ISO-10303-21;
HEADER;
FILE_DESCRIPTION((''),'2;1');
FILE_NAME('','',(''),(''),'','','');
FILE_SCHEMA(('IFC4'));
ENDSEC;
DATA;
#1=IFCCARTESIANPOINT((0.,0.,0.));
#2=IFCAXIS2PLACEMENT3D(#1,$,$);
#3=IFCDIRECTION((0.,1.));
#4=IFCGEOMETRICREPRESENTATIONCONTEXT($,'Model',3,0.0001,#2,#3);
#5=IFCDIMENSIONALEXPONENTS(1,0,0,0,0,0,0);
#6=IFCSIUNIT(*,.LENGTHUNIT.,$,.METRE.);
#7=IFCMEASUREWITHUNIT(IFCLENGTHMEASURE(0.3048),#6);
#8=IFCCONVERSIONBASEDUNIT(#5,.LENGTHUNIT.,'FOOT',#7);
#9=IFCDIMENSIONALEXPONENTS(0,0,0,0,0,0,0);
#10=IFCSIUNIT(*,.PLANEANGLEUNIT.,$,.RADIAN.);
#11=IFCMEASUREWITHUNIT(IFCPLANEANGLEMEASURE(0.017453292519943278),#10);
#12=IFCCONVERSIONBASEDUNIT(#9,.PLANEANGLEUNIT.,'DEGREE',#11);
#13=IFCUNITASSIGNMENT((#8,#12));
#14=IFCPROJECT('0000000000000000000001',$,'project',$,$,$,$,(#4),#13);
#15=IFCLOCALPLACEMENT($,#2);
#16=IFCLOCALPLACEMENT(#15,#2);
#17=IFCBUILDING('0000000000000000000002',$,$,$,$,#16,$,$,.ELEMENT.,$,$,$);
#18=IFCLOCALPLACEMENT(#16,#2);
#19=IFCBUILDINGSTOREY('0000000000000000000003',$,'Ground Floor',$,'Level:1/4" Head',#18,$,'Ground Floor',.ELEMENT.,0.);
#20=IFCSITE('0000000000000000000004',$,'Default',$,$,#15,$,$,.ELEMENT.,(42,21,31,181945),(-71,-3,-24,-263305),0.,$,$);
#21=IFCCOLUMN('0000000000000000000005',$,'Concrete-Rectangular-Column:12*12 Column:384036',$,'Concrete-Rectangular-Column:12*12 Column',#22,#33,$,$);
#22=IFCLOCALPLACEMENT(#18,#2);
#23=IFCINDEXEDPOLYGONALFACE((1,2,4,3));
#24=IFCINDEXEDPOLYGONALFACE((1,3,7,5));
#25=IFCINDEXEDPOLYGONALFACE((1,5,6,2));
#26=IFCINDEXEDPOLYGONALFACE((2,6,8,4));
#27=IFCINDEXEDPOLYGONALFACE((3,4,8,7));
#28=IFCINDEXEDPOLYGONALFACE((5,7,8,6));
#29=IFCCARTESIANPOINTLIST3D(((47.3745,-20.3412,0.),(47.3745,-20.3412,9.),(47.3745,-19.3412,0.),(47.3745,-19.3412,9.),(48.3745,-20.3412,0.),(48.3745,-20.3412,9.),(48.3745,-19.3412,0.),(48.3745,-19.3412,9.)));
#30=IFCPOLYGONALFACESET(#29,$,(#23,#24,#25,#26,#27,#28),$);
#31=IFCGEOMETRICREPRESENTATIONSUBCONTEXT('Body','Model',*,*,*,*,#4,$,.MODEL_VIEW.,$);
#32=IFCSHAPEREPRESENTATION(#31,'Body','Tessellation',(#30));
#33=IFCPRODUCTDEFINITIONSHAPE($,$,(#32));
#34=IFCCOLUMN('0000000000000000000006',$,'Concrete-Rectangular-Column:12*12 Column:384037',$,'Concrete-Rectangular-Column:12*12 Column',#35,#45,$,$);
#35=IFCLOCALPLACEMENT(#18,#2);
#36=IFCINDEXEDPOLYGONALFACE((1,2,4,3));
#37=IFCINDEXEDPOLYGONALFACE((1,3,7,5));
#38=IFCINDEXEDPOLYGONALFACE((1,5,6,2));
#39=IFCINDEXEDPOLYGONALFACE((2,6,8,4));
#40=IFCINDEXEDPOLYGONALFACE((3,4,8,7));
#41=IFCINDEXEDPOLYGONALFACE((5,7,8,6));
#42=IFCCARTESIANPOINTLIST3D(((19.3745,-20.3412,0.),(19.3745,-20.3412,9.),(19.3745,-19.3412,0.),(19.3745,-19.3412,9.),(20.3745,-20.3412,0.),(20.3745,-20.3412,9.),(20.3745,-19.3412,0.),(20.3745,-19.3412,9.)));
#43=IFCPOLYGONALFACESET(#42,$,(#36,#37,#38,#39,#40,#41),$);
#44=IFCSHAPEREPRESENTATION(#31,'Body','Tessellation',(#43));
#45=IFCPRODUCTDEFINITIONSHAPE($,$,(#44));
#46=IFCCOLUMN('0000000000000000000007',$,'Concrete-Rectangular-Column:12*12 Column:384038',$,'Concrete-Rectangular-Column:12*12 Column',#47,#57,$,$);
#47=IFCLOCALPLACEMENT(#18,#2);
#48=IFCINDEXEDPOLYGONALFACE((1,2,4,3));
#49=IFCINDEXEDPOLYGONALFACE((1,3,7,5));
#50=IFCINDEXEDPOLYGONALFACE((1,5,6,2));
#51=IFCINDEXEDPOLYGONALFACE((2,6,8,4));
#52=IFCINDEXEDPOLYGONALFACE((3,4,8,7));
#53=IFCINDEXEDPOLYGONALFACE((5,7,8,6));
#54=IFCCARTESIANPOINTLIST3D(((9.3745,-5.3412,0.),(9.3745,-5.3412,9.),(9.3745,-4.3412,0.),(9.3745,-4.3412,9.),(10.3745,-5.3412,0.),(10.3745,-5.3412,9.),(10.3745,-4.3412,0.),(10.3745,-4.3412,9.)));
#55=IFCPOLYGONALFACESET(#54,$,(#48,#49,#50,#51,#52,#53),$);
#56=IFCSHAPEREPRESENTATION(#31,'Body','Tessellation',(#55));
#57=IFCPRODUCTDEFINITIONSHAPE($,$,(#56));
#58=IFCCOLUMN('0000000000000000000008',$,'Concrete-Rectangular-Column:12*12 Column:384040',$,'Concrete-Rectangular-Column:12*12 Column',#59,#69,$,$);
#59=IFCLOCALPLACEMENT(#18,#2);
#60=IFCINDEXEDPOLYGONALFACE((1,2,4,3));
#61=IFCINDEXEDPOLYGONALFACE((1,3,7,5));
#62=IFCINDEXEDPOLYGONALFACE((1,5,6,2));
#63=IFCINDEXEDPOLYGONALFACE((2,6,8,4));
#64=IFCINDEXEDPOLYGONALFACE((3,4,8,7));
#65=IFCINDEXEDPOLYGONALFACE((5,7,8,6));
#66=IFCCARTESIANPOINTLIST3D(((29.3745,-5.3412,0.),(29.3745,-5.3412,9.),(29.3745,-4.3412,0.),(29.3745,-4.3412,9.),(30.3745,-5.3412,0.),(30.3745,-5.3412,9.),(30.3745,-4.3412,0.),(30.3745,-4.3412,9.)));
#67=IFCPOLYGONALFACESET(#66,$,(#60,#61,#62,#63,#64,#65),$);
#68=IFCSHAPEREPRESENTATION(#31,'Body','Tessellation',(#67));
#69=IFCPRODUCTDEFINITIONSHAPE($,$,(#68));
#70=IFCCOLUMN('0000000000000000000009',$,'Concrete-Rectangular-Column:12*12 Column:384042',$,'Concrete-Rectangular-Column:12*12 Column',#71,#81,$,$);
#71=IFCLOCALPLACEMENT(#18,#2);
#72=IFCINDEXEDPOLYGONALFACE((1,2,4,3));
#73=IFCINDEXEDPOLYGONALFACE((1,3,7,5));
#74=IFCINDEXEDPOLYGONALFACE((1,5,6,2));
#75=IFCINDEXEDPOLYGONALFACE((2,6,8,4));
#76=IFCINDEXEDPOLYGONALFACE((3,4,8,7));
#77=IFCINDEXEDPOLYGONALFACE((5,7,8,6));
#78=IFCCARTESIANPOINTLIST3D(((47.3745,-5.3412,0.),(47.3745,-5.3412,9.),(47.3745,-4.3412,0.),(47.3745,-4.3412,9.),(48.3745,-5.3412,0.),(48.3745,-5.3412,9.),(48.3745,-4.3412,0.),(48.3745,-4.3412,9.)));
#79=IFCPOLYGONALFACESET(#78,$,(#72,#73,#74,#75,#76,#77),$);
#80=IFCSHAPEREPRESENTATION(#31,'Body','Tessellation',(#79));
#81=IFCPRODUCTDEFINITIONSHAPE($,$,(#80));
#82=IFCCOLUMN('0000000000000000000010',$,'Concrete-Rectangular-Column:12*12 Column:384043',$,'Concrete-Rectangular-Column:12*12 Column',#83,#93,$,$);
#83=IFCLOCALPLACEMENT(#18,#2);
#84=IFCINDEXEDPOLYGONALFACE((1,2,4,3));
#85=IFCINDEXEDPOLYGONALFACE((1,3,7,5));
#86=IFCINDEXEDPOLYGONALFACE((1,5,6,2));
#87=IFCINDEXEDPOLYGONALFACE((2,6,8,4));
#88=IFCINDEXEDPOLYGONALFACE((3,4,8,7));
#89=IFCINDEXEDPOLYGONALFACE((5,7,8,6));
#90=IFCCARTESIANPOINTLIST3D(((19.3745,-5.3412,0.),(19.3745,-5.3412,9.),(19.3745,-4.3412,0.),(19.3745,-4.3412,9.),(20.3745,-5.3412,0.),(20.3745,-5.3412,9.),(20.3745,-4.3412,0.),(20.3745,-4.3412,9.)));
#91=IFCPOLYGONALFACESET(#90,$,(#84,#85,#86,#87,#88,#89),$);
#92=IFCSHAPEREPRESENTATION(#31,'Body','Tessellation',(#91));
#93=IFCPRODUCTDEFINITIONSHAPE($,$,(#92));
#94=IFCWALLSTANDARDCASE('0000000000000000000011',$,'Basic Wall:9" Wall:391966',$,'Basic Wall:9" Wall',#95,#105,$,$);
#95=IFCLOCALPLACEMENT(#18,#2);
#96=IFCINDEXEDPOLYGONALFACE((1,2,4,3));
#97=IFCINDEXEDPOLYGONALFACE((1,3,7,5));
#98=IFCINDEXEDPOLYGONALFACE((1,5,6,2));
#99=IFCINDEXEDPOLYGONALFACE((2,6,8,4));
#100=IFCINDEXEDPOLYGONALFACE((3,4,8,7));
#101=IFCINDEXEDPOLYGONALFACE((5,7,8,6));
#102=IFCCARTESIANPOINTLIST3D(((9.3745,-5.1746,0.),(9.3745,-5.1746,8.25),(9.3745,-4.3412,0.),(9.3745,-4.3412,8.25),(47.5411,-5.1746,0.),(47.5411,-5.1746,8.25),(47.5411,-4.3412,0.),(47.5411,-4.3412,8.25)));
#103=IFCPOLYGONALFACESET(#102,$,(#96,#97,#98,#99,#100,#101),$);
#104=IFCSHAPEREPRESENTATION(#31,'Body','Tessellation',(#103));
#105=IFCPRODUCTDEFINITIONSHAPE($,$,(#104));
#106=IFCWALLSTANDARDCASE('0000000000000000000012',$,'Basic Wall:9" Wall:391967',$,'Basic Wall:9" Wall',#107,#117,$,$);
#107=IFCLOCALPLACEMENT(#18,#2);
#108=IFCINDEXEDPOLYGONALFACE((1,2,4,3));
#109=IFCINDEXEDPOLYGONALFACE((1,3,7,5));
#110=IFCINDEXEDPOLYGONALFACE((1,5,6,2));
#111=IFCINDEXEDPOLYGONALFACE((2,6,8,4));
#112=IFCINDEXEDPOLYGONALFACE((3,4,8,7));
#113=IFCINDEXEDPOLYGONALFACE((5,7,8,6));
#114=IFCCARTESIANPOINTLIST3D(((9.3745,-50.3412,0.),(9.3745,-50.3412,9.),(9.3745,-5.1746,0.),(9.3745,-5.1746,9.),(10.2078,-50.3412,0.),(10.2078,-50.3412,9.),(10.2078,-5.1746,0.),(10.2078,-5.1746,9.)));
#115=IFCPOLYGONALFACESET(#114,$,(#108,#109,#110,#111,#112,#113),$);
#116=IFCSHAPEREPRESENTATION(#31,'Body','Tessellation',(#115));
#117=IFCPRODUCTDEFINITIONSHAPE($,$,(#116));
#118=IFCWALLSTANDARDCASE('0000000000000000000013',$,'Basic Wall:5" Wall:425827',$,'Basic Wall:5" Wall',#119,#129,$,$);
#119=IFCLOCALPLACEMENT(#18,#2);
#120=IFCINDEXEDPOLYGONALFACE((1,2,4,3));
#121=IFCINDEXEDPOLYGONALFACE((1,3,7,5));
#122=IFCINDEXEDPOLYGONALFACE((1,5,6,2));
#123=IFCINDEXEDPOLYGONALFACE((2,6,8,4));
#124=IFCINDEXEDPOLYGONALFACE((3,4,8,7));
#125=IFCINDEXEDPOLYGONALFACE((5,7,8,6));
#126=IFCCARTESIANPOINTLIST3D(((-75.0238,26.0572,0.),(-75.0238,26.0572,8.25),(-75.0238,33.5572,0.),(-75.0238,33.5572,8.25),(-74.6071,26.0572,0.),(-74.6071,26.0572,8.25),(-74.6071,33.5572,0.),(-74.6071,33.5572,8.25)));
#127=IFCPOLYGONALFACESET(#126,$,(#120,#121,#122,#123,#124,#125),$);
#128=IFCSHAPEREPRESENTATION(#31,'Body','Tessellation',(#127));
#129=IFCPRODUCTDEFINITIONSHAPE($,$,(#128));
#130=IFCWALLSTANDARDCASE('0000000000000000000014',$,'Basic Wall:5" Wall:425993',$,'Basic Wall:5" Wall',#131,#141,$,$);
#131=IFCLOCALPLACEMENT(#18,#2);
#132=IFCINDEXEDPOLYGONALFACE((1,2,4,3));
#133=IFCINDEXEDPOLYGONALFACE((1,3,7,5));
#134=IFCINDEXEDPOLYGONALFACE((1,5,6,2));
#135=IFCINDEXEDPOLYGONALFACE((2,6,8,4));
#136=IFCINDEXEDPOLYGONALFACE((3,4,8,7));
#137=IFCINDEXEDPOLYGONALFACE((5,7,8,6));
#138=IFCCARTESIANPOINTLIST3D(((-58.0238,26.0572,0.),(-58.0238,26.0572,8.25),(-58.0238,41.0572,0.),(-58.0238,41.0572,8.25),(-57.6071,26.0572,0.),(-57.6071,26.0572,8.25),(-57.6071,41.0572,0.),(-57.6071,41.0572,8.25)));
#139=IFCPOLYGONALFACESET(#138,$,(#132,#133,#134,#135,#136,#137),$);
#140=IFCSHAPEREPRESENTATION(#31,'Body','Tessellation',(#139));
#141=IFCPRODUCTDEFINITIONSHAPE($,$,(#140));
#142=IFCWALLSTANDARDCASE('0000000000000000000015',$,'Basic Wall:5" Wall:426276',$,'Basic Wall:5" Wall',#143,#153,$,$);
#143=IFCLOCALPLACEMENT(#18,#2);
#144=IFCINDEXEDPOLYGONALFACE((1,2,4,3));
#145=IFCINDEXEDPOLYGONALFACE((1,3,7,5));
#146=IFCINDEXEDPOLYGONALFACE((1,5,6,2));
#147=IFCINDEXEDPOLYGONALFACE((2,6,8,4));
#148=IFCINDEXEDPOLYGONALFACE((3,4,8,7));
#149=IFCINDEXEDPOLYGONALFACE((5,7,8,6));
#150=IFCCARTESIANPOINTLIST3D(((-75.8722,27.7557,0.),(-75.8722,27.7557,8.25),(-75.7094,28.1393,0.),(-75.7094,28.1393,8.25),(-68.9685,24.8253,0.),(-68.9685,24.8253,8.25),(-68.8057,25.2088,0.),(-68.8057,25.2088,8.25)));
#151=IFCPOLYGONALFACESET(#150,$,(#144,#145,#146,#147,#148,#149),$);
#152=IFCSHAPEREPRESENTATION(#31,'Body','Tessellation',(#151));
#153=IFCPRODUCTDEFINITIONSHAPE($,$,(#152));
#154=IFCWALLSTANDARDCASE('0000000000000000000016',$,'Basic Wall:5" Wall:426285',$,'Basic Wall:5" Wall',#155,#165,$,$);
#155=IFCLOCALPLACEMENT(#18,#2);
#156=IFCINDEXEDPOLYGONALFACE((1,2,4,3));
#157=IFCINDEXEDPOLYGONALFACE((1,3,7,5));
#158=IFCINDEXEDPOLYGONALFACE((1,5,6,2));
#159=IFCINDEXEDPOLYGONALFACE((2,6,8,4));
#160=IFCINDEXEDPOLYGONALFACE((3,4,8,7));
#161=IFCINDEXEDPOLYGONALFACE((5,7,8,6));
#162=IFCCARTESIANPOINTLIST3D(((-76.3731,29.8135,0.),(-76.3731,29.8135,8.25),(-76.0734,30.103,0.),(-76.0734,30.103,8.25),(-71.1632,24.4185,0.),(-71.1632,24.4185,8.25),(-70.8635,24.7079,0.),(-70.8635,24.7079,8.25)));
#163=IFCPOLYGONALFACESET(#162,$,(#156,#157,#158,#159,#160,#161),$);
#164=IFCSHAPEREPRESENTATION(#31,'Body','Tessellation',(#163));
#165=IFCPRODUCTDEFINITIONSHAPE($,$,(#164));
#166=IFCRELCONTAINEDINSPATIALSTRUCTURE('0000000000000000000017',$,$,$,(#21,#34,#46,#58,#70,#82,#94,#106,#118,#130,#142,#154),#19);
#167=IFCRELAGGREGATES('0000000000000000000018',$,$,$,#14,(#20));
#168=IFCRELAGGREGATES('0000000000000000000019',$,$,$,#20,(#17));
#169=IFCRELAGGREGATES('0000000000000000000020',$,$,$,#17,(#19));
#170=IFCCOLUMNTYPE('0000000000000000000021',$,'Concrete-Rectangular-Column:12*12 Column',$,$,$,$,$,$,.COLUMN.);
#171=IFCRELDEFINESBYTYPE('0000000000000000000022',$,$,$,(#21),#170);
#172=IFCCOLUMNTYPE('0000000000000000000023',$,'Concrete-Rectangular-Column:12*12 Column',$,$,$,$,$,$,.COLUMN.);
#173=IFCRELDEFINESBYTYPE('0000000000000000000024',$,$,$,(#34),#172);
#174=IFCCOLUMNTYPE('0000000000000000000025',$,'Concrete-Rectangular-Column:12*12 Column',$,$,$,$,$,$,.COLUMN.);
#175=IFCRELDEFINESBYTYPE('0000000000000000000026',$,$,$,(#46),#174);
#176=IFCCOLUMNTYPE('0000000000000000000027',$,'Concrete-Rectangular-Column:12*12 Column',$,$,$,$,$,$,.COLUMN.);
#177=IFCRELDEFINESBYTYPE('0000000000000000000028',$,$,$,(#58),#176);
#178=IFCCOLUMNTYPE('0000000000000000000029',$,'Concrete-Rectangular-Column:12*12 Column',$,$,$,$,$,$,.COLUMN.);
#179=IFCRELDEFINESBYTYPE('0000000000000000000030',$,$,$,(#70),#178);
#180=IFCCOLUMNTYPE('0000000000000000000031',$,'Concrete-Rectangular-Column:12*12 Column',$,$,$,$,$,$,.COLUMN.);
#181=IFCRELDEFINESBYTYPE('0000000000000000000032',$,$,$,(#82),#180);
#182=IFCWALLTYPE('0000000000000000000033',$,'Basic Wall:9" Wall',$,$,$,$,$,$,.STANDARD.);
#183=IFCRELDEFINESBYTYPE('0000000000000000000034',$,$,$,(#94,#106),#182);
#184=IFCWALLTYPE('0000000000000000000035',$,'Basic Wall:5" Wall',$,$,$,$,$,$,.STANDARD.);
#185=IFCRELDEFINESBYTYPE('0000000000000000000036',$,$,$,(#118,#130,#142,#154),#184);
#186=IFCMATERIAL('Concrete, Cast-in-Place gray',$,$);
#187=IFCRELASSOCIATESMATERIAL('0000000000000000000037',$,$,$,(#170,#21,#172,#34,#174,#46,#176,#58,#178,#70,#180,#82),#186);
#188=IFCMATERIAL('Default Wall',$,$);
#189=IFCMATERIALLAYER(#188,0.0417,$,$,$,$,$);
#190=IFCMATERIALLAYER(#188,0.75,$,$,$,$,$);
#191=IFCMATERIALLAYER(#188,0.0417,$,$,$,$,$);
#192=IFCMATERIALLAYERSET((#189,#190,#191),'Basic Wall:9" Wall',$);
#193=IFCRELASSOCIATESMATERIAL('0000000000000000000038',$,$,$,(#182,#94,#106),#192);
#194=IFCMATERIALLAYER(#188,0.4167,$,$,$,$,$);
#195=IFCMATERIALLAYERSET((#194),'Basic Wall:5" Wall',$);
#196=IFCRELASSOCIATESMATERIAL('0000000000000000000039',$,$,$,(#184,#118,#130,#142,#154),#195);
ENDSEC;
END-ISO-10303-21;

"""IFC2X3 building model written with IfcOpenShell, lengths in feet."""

from ifc_helpers import new_model, entity, si_unit, converted_unit, direction, frame, frame_2d, origin, origin_2d_with_axis, place, context, subcontext, project, spatial, rectangle, extrude, source, transform, mapped, material, layer, layer_set, layer_usage, type_object, type_shapes, element, save


model = new_model("IFC2X3")

# Units and contexts
model_context = context("Model", 3, precision=0.0001, world=origin(), true_north=direction((0.0, 1.0)))
body_context = subcontext(model_context, "Body", "Model", "MODEL_VIEW")
ifc_project = project(units=[converted_unit("LENGTHUNIT", "FOOT", entity("IfcLengthMeasure", 0.3048), si_unit("LENGTHUNIT", "METRE"), dimensions=[1, 0, 0, 0, 0, 0, 0]), converted_unit("PLANEANGLEUNIT", "DEGREE", entity("IfcPlaneAngleMeasure", 0.017453292519943278), si_unit("PLANEANGLEUNIT", "RADIAN"), dimensions=[0, 0, 0, 0, 0, 0, 0])], contexts=[model_context])

# Site, building, storey
site_placement = place(None, origin())
site = spatial("IfcSite", under=ifc_project, at=site_placement, Name="Default", CompositionType="ELEMENT", RefLatitude=(42, 21, 31, 181945), RefLongitude=(-71, -3, -24, -263305), RefElevation=0.0)
building_placement = place(site_placement, origin())
building = spatial("IfcBuilding", under=site, at=building_placement, CompositionType="ELEMENT")
storey_placement = place(building_placement, origin())
storey = spatial("IfcBuildingStorey", under=building, at=storey_placement, Name="Ground Floor", ObjectType="Level:1/4\" Head", LongName="Ground Floor", CompositionType="ELEMENT", Elevation=0.0)

# Columns
ifc_material_1 = material(Name="Concrete, Cast-in-Place gray")
column_type_1 = type_object("IfcColumnType", Name="Concrete-Rectangular-Column:12*12 Column", PredefinedType="COLUMN", material=ifc_material_1)
shared_shape_1 = source(origin(), body_context, "Body", "SweptSolid", [
    extrude(rectangle(XDim=1.0, YDim=1.0, at=frame_2d((0.0, 0.0), x_axis=(1.0, 0.0))), frame((47.8745, -19.8412, 0.0), z_axis=(0.0, 0.0, 1.0), x_axis=(-1.0, 0.0, 0.0)), (0.0, 0.0, 1.0), 9.0),
])
type_shapes(column_type_1, [shared_shape_1])
column_1_placement = place(storey_placement, origin())
element("IfcColumn", 1, at=column_1_placement, inside=storey, type_object=column_type_1, material=ifc_material_1, Name="Concrete-Rectangular-Column:12*12 Column:384036", ObjectType="Concrete-Rectangular-Column:12*12 Column", context=body_context, shape_type="MappedRepresentation", body=[
    mapped(shared_shape_1, transform((0.0, 0.0, 0.0), scale=1.0)),
])
column_type_2 = type_object("IfcColumnType", Name="Concrete-Rectangular-Column:12*12 Column", PredefinedType="COLUMN", material=ifc_material_1)
shared_shape_2 = source(origin(), body_context, "Body", "SweptSolid", [
    extrude(rectangle(XDim=1.0, YDim=1.0, at=frame_2d((0.0, 0.0), x_axis=(1.0, 0.0))), frame((19.8745, -19.8412, 0.0), z_axis=(0.0, 0.0, 1.0), x_axis=(-1.0, 0.0, 0.0)), (0.0, 0.0, 1.0), 9.0),
])
type_shapes(column_type_2, [shared_shape_2])
column_2_placement = place(storey_placement, origin())
element("IfcColumn", 2, at=column_2_placement, inside=storey, type_object=column_type_2, material=ifc_material_1, Name="Concrete-Rectangular-Column:12*12 Column:384037", ObjectType="Concrete-Rectangular-Column:12*12 Column", context=body_context, shape_type="MappedRepresentation", body=[
    mapped(shared_shape_2, transform((0.0, 0.0, 0.0), scale=1.0)),
])
column_type_3 = type_object("IfcColumnType", Name="Concrete-Rectangular-Column:12*12 Column", PredefinedType="COLUMN", material=ifc_material_1)
shared_shape_3 = source(origin(), body_context, "Body", "SweptSolid", [
    extrude(rectangle(XDim=1.0, YDim=1.0, at=origin_2d_with_axis()), frame((9.8745, -4.8412, 0.0), z_axis=(0.0, 0.0, 1.0), x_axis=(-1.0, 0.0, 0.0)), (0.0, 0.0, 1.0), 9.0),
])
type_shapes(column_type_3, [shared_shape_3])
column_3_placement = place(storey_placement, origin())
element("IfcColumn", 3, at=column_3_placement, inside=storey, type_object=column_type_3, material=ifc_material_1, Name="Concrete-Rectangular-Column:12*12 Column:384038", ObjectType="Concrete-Rectangular-Column:12*12 Column", context=body_context, shape_type="MappedRepresentation", body=[
    mapped(shared_shape_3, transform((0.0, 0.0, 0.0), scale=1.0)),
])
column_type_4 = type_object("IfcColumnType", Name="Concrete-Rectangular-Column:12*12 Column", PredefinedType="COLUMN", material=ifc_material_1)
shared_shape_4 = source(origin(), body_context, "Body", "SweptSolid", [
    extrude(rectangle(XDim=1.0, YDim=1.0, at=frame_2d((0.0, 0.0), x_axis=(1.0, 0.0))), frame((29.8745, -4.8412, 0.0), z_axis=(0.0, 0.0, 1.0), x_axis=(-1.0, 0.0, 0.0)), (0.0, 0.0, 1.0), 9.0),
])
type_shapes(column_type_4, [shared_shape_4])
column_4_placement = place(storey_placement, origin())
element("IfcColumn", 4, at=column_4_placement, inside=storey, type_object=column_type_4, material=ifc_material_1, Name="Concrete-Rectangular-Column:12*12 Column:384040", ObjectType="Concrete-Rectangular-Column:12*12 Column", context=body_context, shape_type="MappedRepresentation", body=[
    mapped(shared_shape_4, transform((0.0, 0.0, 0.0), scale=1.0)),
])
column_type_5 = type_object("IfcColumnType", Name="Concrete-Rectangular-Column:12*12 Column", PredefinedType="COLUMN", material=ifc_material_1)
shared_shape_5 = source(origin(), body_context, "Body", "SweptSolid", [
    extrude(rectangle(XDim=1.0, YDim=1.0, at=frame_2d((0.0, 0.0), x_axis=(1.0, 0.0))), frame((47.8745, -4.8412, 0.0), z_axis=(0.0, 0.0, 1.0), x_axis=(-1.0, 0.0, 0.0)), (0.0, 0.0, 1.0), 9.0),
])
type_shapes(column_type_5, [shared_shape_5])
column_5_placement = place(storey_placement, origin())
element("IfcColumn", 5, at=column_5_placement, inside=storey, type_object=column_type_5, material=ifc_material_1, Name="Concrete-Rectangular-Column:12*12 Column:384042", ObjectType="Concrete-Rectangular-Column:12*12 Column", context=body_context, shape_type="MappedRepresentation", body=[
    mapped(shared_shape_5, transform((0.0, 0.0, 0.0), scale=1.0)),
])
column_type_6 = type_object("IfcColumnType", Name="Concrete-Rectangular-Column:12*12 Column", PredefinedType="COLUMN", material=ifc_material_1)
shared_shape_6 = source(origin(), body_context, "Body", "SweptSolid", [
    extrude(rectangle(XDim=1.0, YDim=1.0, at=frame_2d((0.0, 0.0), x_axis=(1.0, 0.0))), frame((19.8745, -4.8412, 0.0), z_axis=(0.0, 0.0, 1.0), x_axis=(-1.0, 0.0, 0.0)), (0.0, 0.0, 1.0), 9.0),
])
type_shapes(column_type_6, [shared_shape_6])
column_6_placement = place(storey_placement, origin())
element("IfcColumn", 6, at=column_6_placement, inside=storey, type_object=column_type_6, material=ifc_material_1, Name="Concrete-Rectangular-Column:12*12 Column:384043", ObjectType="Concrete-Rectangular-Column:12*12 Column", context=body_context, shape_type="MappedRepresentation", body=[
    mapped(shared_shape_6, transform((0.0, 0.0, 0.0), scale=1.0)),
])

# Walls
ifc_material_2 = material(Name="Default Wall")
ifc_layer_1 = layer(ifc_material_2, 0.0417)
ifc_layer_2 = layer(ifc_material_2, 0.75)
ifc_layer_3 = layer(ifc_material_2, 0.0417)
ifc_layer_set_1 = layer_set([ifc_layer_1, ifc_layer_2, ifc_layer_3], Name="Basic Wall:9\" Wall")
ifc_layer_usage_1 = layer_usage(ifc_layer_set_1, "AXIS2", "NEGATIVE", 0.4167)
wall_type_1 = type_object("IfcWallType", Name="Basic Wall:9\" Wall", PredefinedType="STANDARD", material=ifc_layer_set_1)
wall_1_placement = place(storey_placement, frame((9.3745, -4.7579, 0.0)))
element("IfcWallStandardCase", 7, at=wall_1_placement, inside=storey, type_object=wall_type_1, material=ifc_layer_usage_1, Name="Basic Wall:9\" Wall:391966", ObjectType="Basic Wall:9\" Wall", context=body_context, shape_type="SweptSolid", body=[
    extrude(rectangle(XDim=38.1667, YDim=0.8333, at=frame_2d((19.0833, 0.0), x_axis=(-1.0, 0.0))), origin(), (0.0, 0.0, 1.0), 8.25),
])
wall_2_placement = place(storey_placement, frame((9.7911, -50.3412, 0.0), z_axis=(0.0, 0.0, 1.0), x_axis=(0.0, 1.0, 0.0)))
element("IfcWallStandardCase", 8, at=wall_2_placement, inside=storey, type_object=wall_type_1, material=ifc_layer_usage_1, Name="Basic Wall:9\" Wall:391967", ObjectType="Basic Wall:9\" Wall", context=body_context, shape_type="SweptSolid", body=[
    extrude(rectangle(XDim=45.1667, YDim=0.8333, at=frame_2d((22.5833, 0.0), x_axis=(-1.0, 0.0))), origin(), (0.0, 0.0, 1.0), 9.0),
])
ifc_layer_4 = layer(ifc_material_2, 0.4167)
ifc_layer_set_2 = layer_set([ifc_layer_4], Name="Basic Wall:5\" Wall")
ifc_layer_usage_2 = layer_usage(ifc_layer_set_2, "AXIS2", "NEGATIVE", 0.2083)
wall_type_2 = type_object("IfcWallType", Name="Basic Wall:5\" Wall", PredefinedType="STANDARD", material=ifc_layer_set_2)
wall_3_placement = place(storey_placement, frame((-74.8155, 26.0572, 0.0), z_axis=(0.0, 0.0, 1.0), x_axis=(0.0, 1.0, 0.0)))
element("IfcWallStandardCase", 9, at=wall_3_placement, inside=storey, type_object=wall_type_2, material=ifc_layer_usage_2, Name="Basic Wall:5\" Wall:425827", ObjectType="Basic Wall:5\" Wall", context=body_context, shape_type="SweptSolid", body=[
    extrude(rectangle(XDim=7.5, YDim=0.4167, at=frame_2d((3.75, 0.0), x_axis=(-1.0, 0.0))), origin(), (0.0, 0.0, 1.0), 8.25),
])
wall_4_placement = place(storey_placement, frame((-57.8155, 26.0572, 0.0), z_axis=(0.0, 0.0, 1.0), x_axis=(0.0, 1.0, 0.0)))
element("IfcWallStandardCase", 10, at=wall_4_placement, inside=storey, type_object=wall_type_2, material=ifc_layer_usage_2, Name="Basic Wall:5\" Wall:425993", ObjectType="Basic Wall:5\" Wall", context=body_context, shape_type="SweptSolid", body=[
    extrude(rectangle(XDim=15.0, YDim=0.4167, at=frame_2d((7.5, 0.0), x_axis=(-1.0, 0.0))), origin(), (0.0, 0.0, 1.0), 8.25),
])
wall_5_placement = place(storey_placement, frame((-68.8871, 25.017, 0.0), z_axis=(0.0, 0.0, 1.0), x_axis=(-0.920505, 0.390731, 0.0)))
element("IfcWallStandardCase", 11, at=wall_5_placement, inside=storey, type_object=wall_type_2, material=ifc_layer_usage_2, Name="Basic Wall:5\" Wall:426276", ObjectType="Basic Wall:5\" Wall", context=body_context, shape_type="SweptSolid", body=[
    extrude(rectangle(XDim=7.5, YDim=0.4167, at=frame_2d((3.75, 0.0), x_axis=(-1.0, 0.0))), origin(), (0.0, 0.0, 1.0), 8.25),
])
wall_6_placement = place(storey_placement, frame((-71.0133, 24.5632, 0.0), z_axis=(0.0, 0.0, 1.0), x_axis=(-0.694658, 0.71934, 0.0)))
element("IfcWallStandardCase", 12, at=wall_6_placement, inside=storey, type_object=wall_type_2, material=ifc_layer_usage_2, Name="Basic Wall:5\" Wall:426285", ObjectType="Basic Wall:5\" Wall", context=body_context, shape_type="SweptSolid", body=[
    extrude(rectangle(XDim=7.5, YDim=0.4167, at=frame_2d((3.75, 0.0), x_axis=(-1.0, 0.0))), origin(), (0.0, 0.0, 1.0), 8.25),
])

save(model, "model.ifc")
